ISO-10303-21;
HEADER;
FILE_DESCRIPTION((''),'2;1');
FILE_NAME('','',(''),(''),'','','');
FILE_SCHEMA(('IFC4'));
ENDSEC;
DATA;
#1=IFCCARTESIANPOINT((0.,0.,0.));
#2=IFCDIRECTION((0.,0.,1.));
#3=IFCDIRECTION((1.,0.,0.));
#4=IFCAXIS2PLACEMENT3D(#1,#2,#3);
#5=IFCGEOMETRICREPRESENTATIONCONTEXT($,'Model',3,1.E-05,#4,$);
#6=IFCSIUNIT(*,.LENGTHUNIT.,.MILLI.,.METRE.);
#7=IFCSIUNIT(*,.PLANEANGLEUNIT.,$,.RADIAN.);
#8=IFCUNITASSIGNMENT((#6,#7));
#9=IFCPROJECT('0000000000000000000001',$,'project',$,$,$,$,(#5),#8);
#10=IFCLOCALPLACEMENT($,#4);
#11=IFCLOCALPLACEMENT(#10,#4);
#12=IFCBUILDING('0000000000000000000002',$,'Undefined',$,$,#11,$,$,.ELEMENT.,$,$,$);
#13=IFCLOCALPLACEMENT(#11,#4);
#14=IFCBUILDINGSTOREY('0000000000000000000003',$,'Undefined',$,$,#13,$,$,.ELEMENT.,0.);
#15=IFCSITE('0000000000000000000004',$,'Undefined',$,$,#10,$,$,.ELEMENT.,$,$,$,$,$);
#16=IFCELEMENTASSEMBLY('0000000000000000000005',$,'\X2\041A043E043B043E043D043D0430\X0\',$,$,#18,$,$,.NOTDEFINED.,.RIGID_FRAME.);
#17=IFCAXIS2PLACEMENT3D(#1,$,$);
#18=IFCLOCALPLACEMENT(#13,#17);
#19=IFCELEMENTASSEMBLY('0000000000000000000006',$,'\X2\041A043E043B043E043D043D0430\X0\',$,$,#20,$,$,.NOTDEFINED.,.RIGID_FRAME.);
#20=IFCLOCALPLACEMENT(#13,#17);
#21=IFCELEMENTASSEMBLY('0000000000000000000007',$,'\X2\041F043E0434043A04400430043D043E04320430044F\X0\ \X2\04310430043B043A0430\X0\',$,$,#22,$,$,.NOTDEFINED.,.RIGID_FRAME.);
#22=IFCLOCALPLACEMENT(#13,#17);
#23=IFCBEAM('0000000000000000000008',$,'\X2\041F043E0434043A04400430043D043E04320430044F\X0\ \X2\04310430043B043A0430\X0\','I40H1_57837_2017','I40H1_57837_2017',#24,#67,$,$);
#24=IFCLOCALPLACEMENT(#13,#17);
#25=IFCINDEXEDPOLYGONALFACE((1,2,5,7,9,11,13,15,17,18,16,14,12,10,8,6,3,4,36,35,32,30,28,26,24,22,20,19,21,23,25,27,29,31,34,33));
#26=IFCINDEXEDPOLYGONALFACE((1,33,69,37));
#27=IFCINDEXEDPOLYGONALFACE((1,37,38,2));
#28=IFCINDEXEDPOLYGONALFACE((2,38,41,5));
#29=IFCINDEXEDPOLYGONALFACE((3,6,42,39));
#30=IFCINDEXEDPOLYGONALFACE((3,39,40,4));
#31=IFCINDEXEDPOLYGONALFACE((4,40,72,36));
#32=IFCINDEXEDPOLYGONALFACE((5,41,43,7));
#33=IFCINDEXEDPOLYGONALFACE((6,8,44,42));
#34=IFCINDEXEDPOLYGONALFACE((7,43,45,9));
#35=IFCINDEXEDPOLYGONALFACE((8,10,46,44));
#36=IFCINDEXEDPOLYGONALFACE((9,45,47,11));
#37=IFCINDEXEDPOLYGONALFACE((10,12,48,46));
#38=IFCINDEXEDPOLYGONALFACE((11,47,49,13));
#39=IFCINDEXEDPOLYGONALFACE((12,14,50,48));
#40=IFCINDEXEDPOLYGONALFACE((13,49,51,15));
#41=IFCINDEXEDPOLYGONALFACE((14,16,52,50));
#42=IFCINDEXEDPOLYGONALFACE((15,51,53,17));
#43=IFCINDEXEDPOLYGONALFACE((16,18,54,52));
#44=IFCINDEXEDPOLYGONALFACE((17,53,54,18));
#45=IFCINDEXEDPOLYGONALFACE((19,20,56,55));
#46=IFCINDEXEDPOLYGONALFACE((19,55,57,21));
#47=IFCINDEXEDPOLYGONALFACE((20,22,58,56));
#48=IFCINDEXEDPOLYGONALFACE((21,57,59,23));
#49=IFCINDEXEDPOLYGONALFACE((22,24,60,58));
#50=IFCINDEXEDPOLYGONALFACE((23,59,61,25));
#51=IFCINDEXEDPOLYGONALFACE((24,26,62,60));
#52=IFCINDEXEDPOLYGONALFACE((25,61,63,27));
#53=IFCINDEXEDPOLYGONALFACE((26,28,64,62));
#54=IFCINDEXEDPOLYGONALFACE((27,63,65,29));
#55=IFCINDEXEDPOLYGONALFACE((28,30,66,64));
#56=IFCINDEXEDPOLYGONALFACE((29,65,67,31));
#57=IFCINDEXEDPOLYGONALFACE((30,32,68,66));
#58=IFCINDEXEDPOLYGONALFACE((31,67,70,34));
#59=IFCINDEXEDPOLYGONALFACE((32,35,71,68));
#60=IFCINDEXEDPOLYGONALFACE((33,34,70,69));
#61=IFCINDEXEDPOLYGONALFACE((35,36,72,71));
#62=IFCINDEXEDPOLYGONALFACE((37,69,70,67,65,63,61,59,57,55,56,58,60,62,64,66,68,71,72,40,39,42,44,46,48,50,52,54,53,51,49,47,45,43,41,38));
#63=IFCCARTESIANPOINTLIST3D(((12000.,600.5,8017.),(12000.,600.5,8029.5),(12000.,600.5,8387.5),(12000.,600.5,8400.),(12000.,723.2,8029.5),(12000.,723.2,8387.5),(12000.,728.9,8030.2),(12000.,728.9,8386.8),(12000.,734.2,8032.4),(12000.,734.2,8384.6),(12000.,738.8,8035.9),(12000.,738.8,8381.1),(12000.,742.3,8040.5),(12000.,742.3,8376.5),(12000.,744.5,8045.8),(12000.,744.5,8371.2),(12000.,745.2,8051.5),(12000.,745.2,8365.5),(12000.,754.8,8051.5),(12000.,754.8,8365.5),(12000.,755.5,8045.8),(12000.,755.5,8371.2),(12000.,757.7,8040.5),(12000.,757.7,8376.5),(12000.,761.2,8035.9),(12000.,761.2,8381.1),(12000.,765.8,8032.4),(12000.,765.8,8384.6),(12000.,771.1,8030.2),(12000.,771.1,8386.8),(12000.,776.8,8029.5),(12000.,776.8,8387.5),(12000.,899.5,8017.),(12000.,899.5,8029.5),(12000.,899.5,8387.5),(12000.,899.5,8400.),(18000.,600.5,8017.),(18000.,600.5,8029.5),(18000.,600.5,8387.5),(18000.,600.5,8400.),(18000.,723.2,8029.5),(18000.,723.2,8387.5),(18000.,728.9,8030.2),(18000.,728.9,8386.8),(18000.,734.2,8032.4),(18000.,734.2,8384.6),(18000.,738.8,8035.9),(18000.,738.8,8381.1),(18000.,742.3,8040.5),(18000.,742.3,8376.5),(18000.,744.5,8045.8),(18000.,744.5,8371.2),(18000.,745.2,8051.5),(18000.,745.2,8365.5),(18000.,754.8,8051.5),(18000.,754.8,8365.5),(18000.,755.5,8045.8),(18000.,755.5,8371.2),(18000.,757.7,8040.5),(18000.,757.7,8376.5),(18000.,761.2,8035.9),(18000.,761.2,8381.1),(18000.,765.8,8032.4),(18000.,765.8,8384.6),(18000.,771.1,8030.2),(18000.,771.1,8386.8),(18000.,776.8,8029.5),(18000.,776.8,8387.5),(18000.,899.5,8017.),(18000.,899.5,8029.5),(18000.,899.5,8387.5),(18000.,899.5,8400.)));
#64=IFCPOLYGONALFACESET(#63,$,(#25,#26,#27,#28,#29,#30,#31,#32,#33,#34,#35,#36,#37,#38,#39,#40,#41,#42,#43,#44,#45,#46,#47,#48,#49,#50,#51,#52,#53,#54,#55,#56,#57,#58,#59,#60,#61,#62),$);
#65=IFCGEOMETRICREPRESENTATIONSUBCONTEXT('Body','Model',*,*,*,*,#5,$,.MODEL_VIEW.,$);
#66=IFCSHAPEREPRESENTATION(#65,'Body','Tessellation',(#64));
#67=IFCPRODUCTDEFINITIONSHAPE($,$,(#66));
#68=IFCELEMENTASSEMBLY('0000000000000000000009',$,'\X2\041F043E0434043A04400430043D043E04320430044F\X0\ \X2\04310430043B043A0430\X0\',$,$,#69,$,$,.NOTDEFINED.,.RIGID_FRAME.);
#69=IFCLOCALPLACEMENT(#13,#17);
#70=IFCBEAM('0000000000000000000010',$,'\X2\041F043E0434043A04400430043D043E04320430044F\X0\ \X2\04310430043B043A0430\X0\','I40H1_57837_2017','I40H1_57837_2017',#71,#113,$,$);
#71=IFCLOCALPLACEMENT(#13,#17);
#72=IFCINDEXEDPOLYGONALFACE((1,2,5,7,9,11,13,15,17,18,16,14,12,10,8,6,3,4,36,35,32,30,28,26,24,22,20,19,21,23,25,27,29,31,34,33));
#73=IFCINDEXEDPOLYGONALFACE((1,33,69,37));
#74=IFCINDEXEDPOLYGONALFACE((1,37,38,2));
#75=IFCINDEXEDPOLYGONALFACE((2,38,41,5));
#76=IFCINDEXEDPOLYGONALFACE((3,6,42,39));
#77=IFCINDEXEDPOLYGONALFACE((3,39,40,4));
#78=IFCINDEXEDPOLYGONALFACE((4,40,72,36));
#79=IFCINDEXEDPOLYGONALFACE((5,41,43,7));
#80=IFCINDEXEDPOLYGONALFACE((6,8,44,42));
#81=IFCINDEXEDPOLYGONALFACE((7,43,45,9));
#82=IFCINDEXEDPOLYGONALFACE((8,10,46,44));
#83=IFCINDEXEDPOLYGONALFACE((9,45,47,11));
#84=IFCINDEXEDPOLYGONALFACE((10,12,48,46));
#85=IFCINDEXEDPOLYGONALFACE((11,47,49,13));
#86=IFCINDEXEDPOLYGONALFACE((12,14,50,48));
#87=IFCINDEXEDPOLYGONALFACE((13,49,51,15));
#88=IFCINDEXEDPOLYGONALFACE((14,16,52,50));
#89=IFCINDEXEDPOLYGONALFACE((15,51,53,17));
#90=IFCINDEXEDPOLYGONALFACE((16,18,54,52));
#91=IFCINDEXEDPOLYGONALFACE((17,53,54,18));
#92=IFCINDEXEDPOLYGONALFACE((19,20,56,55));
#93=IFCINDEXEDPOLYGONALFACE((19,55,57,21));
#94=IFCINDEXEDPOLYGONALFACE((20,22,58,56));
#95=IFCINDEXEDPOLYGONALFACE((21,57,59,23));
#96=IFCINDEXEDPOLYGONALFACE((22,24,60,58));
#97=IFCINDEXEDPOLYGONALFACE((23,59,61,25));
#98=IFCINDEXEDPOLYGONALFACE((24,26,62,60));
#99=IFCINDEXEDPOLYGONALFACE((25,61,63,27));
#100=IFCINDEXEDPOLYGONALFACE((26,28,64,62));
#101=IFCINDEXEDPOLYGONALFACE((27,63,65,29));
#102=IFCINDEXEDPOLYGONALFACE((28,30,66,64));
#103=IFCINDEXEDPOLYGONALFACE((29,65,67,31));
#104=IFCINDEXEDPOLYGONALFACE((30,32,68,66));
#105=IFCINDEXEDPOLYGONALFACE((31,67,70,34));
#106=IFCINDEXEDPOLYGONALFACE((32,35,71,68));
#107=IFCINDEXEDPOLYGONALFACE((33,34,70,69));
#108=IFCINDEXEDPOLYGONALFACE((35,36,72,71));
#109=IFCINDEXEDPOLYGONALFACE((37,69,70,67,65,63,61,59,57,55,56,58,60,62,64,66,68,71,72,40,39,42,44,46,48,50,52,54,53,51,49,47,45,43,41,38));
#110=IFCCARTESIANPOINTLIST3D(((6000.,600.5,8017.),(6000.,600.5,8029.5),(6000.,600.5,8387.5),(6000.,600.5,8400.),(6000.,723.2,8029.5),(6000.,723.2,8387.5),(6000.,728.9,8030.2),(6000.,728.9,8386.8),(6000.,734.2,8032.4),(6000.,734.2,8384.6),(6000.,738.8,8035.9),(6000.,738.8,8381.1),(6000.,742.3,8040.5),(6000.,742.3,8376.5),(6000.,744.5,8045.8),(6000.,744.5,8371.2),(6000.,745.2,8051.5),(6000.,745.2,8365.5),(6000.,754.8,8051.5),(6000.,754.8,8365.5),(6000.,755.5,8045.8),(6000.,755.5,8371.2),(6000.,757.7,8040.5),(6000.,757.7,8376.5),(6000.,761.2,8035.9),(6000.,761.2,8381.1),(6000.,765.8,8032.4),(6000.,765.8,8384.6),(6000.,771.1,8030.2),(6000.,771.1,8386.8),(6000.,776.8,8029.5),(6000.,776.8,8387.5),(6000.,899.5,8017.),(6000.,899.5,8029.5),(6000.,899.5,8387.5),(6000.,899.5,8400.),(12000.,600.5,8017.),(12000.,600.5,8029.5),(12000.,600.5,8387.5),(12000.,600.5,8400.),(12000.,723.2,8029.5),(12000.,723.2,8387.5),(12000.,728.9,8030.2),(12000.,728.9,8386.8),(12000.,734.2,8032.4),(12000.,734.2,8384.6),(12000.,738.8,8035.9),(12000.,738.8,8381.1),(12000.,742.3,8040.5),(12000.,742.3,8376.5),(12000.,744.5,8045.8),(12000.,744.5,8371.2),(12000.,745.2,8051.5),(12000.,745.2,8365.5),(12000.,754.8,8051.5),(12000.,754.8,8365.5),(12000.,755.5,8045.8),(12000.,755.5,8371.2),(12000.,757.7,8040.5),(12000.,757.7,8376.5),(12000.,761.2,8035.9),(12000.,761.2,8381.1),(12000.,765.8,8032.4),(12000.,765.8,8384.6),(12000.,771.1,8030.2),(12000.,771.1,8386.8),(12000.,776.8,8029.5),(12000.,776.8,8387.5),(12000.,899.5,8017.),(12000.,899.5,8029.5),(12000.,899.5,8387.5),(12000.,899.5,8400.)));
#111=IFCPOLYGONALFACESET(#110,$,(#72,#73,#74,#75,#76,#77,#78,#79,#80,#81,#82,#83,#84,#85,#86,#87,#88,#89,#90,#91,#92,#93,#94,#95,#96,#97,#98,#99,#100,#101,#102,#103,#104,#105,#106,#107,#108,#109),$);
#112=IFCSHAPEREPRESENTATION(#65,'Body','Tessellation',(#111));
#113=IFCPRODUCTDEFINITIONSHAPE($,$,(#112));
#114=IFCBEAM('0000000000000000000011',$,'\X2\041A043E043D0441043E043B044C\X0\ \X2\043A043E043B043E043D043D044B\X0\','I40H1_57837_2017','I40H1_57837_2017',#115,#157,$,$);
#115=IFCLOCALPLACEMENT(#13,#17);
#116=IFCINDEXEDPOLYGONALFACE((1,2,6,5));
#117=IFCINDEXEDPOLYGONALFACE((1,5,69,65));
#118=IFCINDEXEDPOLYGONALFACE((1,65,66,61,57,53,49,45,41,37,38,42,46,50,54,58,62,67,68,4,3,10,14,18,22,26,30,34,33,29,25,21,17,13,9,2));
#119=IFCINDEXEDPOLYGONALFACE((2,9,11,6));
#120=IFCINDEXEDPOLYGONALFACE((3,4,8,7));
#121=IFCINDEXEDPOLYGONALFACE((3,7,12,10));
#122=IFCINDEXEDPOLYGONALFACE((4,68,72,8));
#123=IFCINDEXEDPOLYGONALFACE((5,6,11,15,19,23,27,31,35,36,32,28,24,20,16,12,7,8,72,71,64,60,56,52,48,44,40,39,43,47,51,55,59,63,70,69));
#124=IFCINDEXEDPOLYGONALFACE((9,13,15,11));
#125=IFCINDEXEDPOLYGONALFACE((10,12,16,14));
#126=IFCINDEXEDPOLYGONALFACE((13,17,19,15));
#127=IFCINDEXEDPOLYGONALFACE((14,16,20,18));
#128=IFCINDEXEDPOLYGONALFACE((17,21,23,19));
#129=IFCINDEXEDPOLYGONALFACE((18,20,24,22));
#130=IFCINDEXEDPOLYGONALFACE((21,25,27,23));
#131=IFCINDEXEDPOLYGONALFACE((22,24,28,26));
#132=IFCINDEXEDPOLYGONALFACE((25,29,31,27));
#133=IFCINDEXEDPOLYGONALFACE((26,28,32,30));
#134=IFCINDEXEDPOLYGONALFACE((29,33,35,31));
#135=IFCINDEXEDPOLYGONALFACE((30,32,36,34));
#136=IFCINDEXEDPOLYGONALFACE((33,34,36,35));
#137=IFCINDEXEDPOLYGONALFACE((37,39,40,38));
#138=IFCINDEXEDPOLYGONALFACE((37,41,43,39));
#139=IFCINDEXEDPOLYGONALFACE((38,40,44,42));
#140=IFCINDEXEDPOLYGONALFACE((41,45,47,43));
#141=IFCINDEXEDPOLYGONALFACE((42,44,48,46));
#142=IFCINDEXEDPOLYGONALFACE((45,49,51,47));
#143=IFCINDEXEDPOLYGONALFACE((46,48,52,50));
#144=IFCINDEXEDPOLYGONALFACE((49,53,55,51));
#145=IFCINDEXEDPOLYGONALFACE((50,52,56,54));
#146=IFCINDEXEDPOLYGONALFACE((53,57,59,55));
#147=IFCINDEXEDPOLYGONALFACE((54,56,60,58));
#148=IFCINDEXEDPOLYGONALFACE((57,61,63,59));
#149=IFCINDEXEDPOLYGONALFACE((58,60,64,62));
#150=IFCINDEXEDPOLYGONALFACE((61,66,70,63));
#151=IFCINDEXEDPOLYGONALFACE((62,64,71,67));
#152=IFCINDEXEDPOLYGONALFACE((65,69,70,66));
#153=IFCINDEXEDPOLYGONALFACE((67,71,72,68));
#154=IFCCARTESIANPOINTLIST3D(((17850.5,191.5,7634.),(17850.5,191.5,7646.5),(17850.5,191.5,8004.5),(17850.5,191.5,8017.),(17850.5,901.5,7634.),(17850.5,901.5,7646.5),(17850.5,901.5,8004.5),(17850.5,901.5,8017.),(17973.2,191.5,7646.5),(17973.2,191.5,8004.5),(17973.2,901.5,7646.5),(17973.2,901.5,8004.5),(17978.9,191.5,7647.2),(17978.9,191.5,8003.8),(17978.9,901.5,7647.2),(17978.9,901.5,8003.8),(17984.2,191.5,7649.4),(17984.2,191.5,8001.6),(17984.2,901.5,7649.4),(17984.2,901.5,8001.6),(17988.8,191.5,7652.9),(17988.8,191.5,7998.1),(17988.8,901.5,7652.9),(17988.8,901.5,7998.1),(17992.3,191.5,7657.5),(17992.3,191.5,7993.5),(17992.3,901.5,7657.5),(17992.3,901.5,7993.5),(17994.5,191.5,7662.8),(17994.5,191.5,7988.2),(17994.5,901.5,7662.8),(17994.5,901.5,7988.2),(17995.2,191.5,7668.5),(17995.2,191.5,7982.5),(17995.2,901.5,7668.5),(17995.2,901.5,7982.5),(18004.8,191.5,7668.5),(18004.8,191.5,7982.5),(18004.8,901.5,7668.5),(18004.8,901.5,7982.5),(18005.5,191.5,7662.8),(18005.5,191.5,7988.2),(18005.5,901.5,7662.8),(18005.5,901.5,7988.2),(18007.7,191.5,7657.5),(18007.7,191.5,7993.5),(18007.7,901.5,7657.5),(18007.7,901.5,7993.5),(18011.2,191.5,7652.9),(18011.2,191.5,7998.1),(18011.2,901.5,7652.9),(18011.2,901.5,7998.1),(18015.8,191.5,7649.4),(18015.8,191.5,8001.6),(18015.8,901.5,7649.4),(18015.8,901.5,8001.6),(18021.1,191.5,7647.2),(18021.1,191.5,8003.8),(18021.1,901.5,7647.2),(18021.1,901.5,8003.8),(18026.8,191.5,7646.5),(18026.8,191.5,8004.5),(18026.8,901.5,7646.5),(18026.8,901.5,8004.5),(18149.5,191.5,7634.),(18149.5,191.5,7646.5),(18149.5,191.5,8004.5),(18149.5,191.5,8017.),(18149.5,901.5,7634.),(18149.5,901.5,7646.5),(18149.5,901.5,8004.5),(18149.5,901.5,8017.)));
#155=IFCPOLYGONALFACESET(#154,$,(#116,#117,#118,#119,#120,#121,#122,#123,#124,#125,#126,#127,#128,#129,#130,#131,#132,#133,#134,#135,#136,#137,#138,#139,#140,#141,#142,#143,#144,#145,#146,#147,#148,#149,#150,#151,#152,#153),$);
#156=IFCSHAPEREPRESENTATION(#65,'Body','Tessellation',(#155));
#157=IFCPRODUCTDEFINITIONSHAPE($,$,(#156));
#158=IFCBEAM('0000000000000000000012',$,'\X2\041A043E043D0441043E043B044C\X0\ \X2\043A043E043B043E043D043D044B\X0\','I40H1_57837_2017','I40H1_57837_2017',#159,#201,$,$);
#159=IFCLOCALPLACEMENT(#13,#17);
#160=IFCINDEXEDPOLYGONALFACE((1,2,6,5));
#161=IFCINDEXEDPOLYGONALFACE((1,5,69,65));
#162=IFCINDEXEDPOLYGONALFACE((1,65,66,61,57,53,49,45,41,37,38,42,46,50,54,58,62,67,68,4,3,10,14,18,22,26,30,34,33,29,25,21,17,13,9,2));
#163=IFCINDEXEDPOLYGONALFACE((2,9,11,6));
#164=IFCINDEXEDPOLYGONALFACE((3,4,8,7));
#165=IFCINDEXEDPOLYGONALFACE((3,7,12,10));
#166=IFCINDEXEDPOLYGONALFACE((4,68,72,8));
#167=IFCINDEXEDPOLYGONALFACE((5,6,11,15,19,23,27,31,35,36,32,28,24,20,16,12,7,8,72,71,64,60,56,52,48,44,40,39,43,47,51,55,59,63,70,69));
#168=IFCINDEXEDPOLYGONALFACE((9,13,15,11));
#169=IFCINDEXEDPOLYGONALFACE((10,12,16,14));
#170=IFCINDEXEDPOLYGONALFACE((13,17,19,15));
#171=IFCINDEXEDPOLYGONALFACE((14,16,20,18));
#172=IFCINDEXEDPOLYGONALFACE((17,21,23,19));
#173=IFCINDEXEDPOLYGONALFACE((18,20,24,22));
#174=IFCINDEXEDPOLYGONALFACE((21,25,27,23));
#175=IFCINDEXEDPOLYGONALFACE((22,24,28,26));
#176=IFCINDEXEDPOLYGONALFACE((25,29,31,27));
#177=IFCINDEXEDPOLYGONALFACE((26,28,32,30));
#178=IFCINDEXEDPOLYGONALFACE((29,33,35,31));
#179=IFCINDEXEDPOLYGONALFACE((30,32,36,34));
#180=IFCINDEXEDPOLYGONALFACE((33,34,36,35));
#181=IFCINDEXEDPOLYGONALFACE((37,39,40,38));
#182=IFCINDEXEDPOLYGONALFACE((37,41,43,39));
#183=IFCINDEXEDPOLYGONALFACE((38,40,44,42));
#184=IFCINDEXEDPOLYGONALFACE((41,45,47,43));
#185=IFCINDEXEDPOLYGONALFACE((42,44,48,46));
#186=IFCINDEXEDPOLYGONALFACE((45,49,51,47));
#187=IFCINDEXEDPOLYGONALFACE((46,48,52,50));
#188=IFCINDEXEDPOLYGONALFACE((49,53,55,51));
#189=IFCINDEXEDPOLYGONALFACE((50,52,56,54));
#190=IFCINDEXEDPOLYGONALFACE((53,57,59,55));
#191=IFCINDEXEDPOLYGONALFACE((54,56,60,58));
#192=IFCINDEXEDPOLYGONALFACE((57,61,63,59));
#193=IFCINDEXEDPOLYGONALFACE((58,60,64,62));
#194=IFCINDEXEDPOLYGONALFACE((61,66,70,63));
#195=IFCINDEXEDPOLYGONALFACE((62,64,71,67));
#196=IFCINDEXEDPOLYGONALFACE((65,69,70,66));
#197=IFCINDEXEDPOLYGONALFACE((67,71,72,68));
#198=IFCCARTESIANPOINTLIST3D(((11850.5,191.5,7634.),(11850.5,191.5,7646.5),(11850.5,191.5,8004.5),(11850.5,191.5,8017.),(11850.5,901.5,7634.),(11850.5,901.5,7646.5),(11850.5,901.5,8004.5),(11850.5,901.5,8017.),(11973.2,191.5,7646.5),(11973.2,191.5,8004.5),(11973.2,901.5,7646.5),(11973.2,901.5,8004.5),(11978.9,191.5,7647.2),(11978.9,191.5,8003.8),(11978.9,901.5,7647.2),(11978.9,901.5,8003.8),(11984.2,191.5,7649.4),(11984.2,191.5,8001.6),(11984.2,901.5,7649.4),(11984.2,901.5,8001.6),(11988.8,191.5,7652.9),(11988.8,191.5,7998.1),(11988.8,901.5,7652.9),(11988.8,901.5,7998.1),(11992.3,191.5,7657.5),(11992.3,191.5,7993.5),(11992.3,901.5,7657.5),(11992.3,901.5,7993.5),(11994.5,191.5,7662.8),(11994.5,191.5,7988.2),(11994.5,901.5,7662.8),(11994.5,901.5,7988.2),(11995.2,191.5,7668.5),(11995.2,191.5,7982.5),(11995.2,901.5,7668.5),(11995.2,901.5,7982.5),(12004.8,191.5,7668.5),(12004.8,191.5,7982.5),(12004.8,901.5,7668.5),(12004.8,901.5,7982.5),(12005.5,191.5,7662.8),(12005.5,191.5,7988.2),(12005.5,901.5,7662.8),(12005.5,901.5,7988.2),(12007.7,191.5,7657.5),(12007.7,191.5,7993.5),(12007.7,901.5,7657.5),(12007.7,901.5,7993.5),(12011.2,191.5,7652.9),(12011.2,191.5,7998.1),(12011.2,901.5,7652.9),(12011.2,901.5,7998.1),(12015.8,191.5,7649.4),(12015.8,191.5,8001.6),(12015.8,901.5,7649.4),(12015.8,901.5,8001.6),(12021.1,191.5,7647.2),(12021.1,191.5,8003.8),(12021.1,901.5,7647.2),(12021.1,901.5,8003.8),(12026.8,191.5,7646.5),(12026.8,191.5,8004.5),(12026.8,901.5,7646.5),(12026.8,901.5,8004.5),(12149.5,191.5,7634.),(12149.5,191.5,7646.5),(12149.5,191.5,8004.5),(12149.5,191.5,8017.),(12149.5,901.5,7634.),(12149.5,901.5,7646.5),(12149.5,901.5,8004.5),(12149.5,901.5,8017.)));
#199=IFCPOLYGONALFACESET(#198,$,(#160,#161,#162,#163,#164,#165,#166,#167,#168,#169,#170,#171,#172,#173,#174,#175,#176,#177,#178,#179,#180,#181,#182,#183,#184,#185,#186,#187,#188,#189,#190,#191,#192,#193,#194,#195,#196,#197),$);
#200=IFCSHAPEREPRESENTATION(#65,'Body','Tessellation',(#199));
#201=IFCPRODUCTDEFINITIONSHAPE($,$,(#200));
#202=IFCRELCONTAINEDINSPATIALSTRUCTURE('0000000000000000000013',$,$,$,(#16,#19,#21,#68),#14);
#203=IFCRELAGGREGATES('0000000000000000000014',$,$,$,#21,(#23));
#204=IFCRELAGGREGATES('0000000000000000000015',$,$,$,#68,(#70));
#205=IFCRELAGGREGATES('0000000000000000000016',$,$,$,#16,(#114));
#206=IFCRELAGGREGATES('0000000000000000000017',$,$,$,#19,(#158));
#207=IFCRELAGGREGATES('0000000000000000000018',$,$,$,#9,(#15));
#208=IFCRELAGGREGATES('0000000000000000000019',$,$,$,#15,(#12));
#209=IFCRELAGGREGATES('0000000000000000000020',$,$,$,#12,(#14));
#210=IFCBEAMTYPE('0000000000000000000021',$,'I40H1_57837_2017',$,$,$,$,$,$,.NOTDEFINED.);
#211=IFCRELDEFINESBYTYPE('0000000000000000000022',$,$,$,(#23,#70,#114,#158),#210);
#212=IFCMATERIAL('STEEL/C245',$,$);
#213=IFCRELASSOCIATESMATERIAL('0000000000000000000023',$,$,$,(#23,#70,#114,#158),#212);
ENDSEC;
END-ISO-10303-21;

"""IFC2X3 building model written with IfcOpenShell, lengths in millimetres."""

from ifc_helpers import new_model, si_unit, frame, origin_with_axes, origin_2d_with_axis, place, context, subcontext, project, spatial, i_section, extrude, material, type_object, element, aggregate, save


model = new_model("IFC2X3")

# Units and contexts
model_context = context("Model", 3, precision=1e-05, world=origin_with_axes())
body_context = subcontext(model_context, "Body", "Model", "MODEL_VIEW")
ifc_project = project(units=[si_unit("LENGTHUNIT", "METRE", prefix="MILLI"), si_unit("PLANEANGLEUNIT", "RADIAN")], contexts=[model_context])

# Site, building, storey
site_placement = place(None, origin_with_axes())
site = spatial("IfcSite", under=ifc_project, at=site_placement, Name="Undefined", CompositionType="ELEMENT")
building_placement = place(site_placement, origin_with_axes())
building = spatial("IfcBuilding", under=site, at=building_placement, Name="Undefined", CompositionType="ELEMENT")
storey_placement = place(building_placement, origin_with_axes())
storey = spatial("IfcBuildingStorey", under=building, at=storey_placement, Name="Undefined", CompositionType="ELEMENT", Elevation=0.0)

# Element assemblies
assembly_1_placement = place(storey_placement, origin_with_axes())
assembly_1 = element("IfcElementAssembly", 1, at=assembly_1_placement, inside=storey, Name="Колонна", AssemblyPlace="NOTDEFINED", PredefinedType="RIGID_FRAME")
ifc_material_1 = material(Name="STEEL/C245")
assembly_2_placement = place(storey_placement, origin_with_axes())
assembly_2 = element("IfcElementAssembly", 2, at=assembly_2_placement, inside=storey, Name="Колонна", AssemblyPlace="NOTDEFINED", PredefinedType="RIGID_FRAME")

# Element assemblies, beams
beam_type_1 = type_object("IfcBeamType", Name="I40H1_57837_2017", PredefinedType="NOTDEFINED")
assembly_3_placement = place(storey_placement, origin_with_axes())
assembly_3 = element("IfcElementAssembly", 3, at=assembly_3_placement, inside=storey, Name="Подкрановая балка", AssemblyPlace="NOTDEFINED", PredefinedType="RIGID_FRAME")
beam_1_placement = place(assembly_3_placement, frame((18000.0, 750.0, 8208.5), z_axis=(0.0, 0.0, 1.0), x_axis=(-1.0, 0.0, 0.0)))
beam_1 = element("IfcBeam", 4, at=beam_1_placement, type_object=beam_type_1, material=ifc_material_1, Name="Подкрановая балка", Description="I40H1_57837_2017", ObjectType="I40H1_57837_2017", context=body_context, shape_type="SweptSolid", body=[
    extrude(i_section(OverallWidth=299.0, OverallDepth=383.0, WebThickness=9.5, FlangeThickness=12.5, FilletRadius=22.0, at=origin_2d_with_axis()), frame((6000.0, 0.0, 0.0), z_axis=(-1.0, 0.0, 0.0), x_axis=(0.0, -1.0, 0.0)), (0.0, 0.0, 1.0), 6000.0),
])
aggregate(assembly_3, [beam_1])
assembly_4_placement = place(storey_placement, origin_with_axes())
assembly_4 = element("IfcElementAssembly", 5, at=assembly_4_placement, inside=storey, Name="Подкрановая балка", AssemblyPlace="NOTDEFINED", PredefinedType="RIGID_FRAME")
beam_2_placement = place(assembly_4_placement, frame((12000.0, 750.0, 8208.5), z_axis=(0.0, 0.0, 1.0), x_axis=(-1.0, 0.0, 0.0)))
beam_2 = element("IfcBeam", 6, at=beam_2_placement, type_object=beam_type_1, material=ifc_material_1, Name="Подкрановая балка", Description="I40H1_57837_2017", ObjectType="I40H1_57837_2017", context=body_context, shape_type="SweptSolid", body=[
    extrude(i_section(OverallWidth=299.0, OverallDepth=383.0, WebThickness=9.5, FlangeThickness=12.5, FilletRadius=22.0, at=origin_2d_with_axis()), frame((6000.0, 0.0, 0.0), z_axis=(-1.0, 0.0, 0.0), x_axis=(0.0, -1.0, 0.0)), (0.0, 0.0, 1.0), 6000.0),
])
aggregate(assembly_4, [beam_2])

# Beams
beam_3_placement = place(assembly_1_placement, frame((18000.0, 901.5, 7825.5), z_axis=(0.0, 0.0, 1.0), x_axis=(0.0, -1.0, 0.0)))
beam_3 = element("IfcBeam", 7, at=beam_3_placement, type_object=beam_type_1, material=ifc_material_1, Name="Консоль колонны", Description="I40H1_57837_2017", ObjectType="I40H1_57837_2017", context=body_context, shape_type="SweptSolid", body=[
    extrude(i_section(OverallWidth=299.0, OverallDepth=383.0, WebThickness=9.5, FlangeThickness=12.5, FilletRadius=22.0, at=origin_2d_with_axis()), frame((710.0, 0.0, 0.0), z_axis=(-1.0, 0.0, 0.0), x_axis=(0.0, -1.0, 0.0)), (0.0, 0.0, 1.0), 710.0),
])
aggregate(assembly_1, [beam_3])
beam_4_placement = place(assembly_2_placement, frame((12000.0, 901.5, 7825.5), z_axis=(0.0, 0.0, 1.0), x_axis=(0.0, -1.0, 0.0)))
beam_4 = element("IfcBeam", 8, at=beam_4_placement, type_object=beam_type_1, material=ifc_material_1, Name="Консоль колонны", Description="I40H1_57837_2017", ObjectType="I40H1_57837_2017", context=body_context, shape_type="SweptSolid", body=[
    extrude(i_section(OverallWidth=299.0, OverallDepth=383.0, WebThickness=9.5, FlangeThickness=12.5, FilletRadius=22.0, at=origin_2d_with_axis()), frame((710.0, 0.0, 0.0), z_axis=(-1.0, 0.0, 0.0), x_axis=(0.0, -1.0, 0.0)), (0.0, 0.0, 1.0), 710.0),
])
aggregate(assembly_2, [beam_4])

save(model, "model.ifc")
